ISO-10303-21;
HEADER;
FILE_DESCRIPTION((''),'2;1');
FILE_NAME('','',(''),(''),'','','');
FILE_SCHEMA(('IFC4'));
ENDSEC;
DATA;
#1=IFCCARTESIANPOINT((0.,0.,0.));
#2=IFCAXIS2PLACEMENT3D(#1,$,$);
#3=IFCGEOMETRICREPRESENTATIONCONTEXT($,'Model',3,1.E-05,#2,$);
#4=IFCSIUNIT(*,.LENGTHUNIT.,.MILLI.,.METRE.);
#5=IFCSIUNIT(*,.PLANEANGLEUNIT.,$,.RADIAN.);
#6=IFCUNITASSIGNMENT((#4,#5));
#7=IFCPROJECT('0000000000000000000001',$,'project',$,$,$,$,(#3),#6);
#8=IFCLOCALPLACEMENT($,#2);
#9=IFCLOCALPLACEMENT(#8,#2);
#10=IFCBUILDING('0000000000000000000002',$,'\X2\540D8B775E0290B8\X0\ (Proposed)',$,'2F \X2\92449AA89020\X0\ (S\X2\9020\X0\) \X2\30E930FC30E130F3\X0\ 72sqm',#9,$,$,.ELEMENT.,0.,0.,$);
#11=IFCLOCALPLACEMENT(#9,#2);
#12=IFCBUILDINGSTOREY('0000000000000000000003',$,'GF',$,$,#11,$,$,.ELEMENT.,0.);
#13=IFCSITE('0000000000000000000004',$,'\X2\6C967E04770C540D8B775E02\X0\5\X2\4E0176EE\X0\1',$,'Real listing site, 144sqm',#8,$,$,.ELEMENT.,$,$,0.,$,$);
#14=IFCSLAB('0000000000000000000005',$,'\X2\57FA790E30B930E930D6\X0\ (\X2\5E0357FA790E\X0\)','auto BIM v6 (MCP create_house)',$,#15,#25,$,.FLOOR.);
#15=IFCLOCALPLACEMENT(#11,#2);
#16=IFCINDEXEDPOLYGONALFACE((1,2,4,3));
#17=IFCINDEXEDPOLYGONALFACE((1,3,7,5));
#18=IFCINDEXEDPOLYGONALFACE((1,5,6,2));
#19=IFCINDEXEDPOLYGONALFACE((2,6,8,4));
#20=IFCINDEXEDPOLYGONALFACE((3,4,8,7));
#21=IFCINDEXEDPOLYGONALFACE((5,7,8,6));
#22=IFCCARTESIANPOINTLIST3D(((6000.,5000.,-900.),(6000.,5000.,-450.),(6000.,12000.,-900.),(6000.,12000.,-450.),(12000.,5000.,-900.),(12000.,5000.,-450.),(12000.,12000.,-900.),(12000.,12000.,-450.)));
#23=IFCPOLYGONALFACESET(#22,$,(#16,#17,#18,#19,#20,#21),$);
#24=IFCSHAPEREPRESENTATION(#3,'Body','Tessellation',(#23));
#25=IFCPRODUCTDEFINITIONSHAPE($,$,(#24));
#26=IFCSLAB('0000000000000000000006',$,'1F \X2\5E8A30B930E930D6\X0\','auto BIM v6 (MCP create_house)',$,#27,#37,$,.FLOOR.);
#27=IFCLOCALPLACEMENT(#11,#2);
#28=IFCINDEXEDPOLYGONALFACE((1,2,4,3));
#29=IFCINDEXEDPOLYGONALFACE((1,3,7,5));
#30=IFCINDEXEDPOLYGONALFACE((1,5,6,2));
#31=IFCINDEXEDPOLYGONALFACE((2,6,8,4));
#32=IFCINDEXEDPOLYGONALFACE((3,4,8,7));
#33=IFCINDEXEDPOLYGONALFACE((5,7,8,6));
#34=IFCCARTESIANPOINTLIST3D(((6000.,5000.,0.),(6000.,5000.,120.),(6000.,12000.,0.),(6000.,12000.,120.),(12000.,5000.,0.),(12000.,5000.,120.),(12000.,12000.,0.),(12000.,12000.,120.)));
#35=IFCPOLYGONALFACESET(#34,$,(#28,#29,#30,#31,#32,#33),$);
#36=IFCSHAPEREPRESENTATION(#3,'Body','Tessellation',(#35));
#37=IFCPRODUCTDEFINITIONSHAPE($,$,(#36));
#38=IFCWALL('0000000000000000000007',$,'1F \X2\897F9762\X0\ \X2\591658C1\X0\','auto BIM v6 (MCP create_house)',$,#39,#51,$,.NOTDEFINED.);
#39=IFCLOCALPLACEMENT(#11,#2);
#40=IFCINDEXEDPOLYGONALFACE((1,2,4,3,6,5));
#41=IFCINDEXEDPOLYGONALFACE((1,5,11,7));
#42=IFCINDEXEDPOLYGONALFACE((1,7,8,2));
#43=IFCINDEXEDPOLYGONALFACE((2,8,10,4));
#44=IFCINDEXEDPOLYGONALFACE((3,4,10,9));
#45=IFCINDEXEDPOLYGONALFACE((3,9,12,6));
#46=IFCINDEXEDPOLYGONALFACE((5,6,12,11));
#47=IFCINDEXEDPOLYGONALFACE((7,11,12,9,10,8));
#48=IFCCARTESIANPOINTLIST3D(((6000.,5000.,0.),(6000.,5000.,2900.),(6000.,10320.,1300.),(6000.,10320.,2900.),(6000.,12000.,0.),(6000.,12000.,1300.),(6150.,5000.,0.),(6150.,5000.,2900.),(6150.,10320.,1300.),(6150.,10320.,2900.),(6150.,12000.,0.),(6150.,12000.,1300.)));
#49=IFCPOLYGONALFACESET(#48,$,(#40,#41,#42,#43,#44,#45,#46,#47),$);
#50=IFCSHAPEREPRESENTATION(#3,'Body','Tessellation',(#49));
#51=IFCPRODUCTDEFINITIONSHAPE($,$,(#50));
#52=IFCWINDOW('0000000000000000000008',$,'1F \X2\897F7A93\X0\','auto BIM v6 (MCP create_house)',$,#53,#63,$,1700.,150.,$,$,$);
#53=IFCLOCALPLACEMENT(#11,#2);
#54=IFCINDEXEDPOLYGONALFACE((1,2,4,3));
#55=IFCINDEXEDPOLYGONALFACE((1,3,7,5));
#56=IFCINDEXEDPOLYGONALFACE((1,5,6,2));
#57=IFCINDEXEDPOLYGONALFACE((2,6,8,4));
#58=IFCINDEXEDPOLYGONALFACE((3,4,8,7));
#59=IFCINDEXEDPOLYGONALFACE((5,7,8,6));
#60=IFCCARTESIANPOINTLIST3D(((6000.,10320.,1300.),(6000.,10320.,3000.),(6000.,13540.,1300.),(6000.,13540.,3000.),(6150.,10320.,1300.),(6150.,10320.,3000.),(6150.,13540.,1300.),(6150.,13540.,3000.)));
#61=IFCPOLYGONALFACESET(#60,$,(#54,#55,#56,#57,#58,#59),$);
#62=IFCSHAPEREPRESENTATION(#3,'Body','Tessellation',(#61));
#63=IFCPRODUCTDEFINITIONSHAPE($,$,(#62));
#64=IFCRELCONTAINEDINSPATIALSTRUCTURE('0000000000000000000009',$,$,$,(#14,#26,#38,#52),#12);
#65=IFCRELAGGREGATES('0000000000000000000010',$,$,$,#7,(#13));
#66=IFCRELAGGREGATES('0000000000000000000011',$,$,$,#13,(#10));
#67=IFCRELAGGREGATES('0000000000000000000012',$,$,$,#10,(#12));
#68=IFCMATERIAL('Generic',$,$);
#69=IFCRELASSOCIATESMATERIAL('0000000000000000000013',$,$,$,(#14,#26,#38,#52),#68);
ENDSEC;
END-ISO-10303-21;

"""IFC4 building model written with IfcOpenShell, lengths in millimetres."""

from ifc_helpers import new_model, si_unit, frame, frame_2d, origin, place, context, project, spatial, rectangle, extrude, material, element, fill, save


model = new_model("IFC4")

# Units and contexts
model_context = context("Model", 3, precision=1e-05, world=origin())
ifc_project = project(units=[si_unit("LENGTHUNIT", "METRE", prefix="MILLI"), si_unit("PLANEANGLEUNIT", "RADIAN")], contexts=[model_context])

# Site, building, storey
site_placement = place(None, origin())
site = spatial("IfcSite", under=ifc_project, at=site_placement, Name="沖縄県名護市5丁目1", ObjectType="Real listing site, 144sqm", CompositionType="ELEMENT", RefElevation=0.0)
building_placement = place(site_placement, origin())
building = spatial("IfcBuilding", under=site, at=building_placement, Name="名護市邸 (Proposed)", ObjectType="2F 鉄骨造 (S造) ラーメン 72sqm", CompositionType="ELEMENT", ElevationOfRefHeight=0.0, ElevationOfTerrain=0.0)
storey_placement = place(building_placement, origin())
storey = spatial("IfcBuildingStorey", under=building, at=storey_placement, Name="GF", CompositionType="ELEMENT", Elevation=0.0)

# Slabs
ifc_material = material(Name="Generic")
slab_1_placement = place(storey_placement, frame((3000.0, 2500.0, -450.0)))
element("IfcSlab", 1, at=slab_1_placement, inside=storey, material=ifc_material, Name="基礎スラブ (布基礎)", Description="auto BIM v6 (MCP create_house)", PredefinedType="FLOOR", context=model_context, shape_type="SweptSolid", body=[
    extrude(rectangle(XDim=6000.0, YDim=7000.0, at=frame_2d((3000.0, 3500.0))), frame((3000.0, 2500.0, -450.0)), (0.0, 0.0, 1.0), 450.0),
])
slab_2_placement = place(storey_placement, frame((3000.0, 2500.0, 0.0)))
element("IfcSlab", 2, at=slab_2_placement, inside=storey, material=ifc_material, Name="1F 床スラブ", Description="auto BIM v6 (MCP create_house)", PredefinedType="FLOOR", context=model_context, shape_type="SweptSolid", body=[
    extrude(rectangle(XDim=6000.0, YDim=7000.0, at=frame_2d((3000.0, 3500.0))), frame((3000.0, 2500.0, 0.0)), (0.0, 0.0, 1.0), 120.0),
])

# Wall, opening, window
wall_1_placement = place(storey_placement, frame((3000.0, 2500.0, 0.0)))
wall_1 = element("IfcWall", 3, at=wall_1_placement, inside=storey, material=ifc_material, Name="1F 西面 外壁", Description="auto BIM v6 (MCP create_house)", PredefinedType="NOTDEFINED", context=model_context, shape_type="SweptSolid", body=[
    extrude(rectangle(XDim=150.0, YDim=7000.0, at=frame_2d((75.0, 3500.0))), frame((3000.0, 2500.0, 0.0)), (0.0, 0.0, 1.0), 2900.0),
])
opening_1_placement = place(storey_placement, frame((3000.0, 5160.0, 650.0)))
opening_1 = element("IfcOpeningElement", 4, at=opening_1_placement, cuts=wall_1, PredefinedType="NOTDEFINED", context=model_context, shape_type="SweptSolid", body=[
    extrude(rectangle(XDim=150.0, YDim=3220.0, at=frame_2d((75.0, 1610.0))), frame((3000.0, 5160.0, 650.0)), (0.0, 0.0, 1.0), 1700.0),
])
window_1_placement = place(storey_placement, frame((3000.0, 5160.0, 650.0)))
window_1 = element("IfcWindow", 5, at=window_1_placement, inside=storey, material=ifc_material, Name="1F 西窓", Description="auto BIM v6 (MCP create_house)", OverallHeight=1700.0, OverallWidth=150.0, context=model_context, shape_type="SweptSolid", body=[
    extrude(rectangle(XDim=150.0, YDim=3220.0, at=frame_2d((75.0, 1610.0))), frame((3000.0, 5160.0, 650.0)), (0.0, 0.0, 1.0), 1700.0),
])
fill(opening_1, window_1)

save(model, "model.ifc")
